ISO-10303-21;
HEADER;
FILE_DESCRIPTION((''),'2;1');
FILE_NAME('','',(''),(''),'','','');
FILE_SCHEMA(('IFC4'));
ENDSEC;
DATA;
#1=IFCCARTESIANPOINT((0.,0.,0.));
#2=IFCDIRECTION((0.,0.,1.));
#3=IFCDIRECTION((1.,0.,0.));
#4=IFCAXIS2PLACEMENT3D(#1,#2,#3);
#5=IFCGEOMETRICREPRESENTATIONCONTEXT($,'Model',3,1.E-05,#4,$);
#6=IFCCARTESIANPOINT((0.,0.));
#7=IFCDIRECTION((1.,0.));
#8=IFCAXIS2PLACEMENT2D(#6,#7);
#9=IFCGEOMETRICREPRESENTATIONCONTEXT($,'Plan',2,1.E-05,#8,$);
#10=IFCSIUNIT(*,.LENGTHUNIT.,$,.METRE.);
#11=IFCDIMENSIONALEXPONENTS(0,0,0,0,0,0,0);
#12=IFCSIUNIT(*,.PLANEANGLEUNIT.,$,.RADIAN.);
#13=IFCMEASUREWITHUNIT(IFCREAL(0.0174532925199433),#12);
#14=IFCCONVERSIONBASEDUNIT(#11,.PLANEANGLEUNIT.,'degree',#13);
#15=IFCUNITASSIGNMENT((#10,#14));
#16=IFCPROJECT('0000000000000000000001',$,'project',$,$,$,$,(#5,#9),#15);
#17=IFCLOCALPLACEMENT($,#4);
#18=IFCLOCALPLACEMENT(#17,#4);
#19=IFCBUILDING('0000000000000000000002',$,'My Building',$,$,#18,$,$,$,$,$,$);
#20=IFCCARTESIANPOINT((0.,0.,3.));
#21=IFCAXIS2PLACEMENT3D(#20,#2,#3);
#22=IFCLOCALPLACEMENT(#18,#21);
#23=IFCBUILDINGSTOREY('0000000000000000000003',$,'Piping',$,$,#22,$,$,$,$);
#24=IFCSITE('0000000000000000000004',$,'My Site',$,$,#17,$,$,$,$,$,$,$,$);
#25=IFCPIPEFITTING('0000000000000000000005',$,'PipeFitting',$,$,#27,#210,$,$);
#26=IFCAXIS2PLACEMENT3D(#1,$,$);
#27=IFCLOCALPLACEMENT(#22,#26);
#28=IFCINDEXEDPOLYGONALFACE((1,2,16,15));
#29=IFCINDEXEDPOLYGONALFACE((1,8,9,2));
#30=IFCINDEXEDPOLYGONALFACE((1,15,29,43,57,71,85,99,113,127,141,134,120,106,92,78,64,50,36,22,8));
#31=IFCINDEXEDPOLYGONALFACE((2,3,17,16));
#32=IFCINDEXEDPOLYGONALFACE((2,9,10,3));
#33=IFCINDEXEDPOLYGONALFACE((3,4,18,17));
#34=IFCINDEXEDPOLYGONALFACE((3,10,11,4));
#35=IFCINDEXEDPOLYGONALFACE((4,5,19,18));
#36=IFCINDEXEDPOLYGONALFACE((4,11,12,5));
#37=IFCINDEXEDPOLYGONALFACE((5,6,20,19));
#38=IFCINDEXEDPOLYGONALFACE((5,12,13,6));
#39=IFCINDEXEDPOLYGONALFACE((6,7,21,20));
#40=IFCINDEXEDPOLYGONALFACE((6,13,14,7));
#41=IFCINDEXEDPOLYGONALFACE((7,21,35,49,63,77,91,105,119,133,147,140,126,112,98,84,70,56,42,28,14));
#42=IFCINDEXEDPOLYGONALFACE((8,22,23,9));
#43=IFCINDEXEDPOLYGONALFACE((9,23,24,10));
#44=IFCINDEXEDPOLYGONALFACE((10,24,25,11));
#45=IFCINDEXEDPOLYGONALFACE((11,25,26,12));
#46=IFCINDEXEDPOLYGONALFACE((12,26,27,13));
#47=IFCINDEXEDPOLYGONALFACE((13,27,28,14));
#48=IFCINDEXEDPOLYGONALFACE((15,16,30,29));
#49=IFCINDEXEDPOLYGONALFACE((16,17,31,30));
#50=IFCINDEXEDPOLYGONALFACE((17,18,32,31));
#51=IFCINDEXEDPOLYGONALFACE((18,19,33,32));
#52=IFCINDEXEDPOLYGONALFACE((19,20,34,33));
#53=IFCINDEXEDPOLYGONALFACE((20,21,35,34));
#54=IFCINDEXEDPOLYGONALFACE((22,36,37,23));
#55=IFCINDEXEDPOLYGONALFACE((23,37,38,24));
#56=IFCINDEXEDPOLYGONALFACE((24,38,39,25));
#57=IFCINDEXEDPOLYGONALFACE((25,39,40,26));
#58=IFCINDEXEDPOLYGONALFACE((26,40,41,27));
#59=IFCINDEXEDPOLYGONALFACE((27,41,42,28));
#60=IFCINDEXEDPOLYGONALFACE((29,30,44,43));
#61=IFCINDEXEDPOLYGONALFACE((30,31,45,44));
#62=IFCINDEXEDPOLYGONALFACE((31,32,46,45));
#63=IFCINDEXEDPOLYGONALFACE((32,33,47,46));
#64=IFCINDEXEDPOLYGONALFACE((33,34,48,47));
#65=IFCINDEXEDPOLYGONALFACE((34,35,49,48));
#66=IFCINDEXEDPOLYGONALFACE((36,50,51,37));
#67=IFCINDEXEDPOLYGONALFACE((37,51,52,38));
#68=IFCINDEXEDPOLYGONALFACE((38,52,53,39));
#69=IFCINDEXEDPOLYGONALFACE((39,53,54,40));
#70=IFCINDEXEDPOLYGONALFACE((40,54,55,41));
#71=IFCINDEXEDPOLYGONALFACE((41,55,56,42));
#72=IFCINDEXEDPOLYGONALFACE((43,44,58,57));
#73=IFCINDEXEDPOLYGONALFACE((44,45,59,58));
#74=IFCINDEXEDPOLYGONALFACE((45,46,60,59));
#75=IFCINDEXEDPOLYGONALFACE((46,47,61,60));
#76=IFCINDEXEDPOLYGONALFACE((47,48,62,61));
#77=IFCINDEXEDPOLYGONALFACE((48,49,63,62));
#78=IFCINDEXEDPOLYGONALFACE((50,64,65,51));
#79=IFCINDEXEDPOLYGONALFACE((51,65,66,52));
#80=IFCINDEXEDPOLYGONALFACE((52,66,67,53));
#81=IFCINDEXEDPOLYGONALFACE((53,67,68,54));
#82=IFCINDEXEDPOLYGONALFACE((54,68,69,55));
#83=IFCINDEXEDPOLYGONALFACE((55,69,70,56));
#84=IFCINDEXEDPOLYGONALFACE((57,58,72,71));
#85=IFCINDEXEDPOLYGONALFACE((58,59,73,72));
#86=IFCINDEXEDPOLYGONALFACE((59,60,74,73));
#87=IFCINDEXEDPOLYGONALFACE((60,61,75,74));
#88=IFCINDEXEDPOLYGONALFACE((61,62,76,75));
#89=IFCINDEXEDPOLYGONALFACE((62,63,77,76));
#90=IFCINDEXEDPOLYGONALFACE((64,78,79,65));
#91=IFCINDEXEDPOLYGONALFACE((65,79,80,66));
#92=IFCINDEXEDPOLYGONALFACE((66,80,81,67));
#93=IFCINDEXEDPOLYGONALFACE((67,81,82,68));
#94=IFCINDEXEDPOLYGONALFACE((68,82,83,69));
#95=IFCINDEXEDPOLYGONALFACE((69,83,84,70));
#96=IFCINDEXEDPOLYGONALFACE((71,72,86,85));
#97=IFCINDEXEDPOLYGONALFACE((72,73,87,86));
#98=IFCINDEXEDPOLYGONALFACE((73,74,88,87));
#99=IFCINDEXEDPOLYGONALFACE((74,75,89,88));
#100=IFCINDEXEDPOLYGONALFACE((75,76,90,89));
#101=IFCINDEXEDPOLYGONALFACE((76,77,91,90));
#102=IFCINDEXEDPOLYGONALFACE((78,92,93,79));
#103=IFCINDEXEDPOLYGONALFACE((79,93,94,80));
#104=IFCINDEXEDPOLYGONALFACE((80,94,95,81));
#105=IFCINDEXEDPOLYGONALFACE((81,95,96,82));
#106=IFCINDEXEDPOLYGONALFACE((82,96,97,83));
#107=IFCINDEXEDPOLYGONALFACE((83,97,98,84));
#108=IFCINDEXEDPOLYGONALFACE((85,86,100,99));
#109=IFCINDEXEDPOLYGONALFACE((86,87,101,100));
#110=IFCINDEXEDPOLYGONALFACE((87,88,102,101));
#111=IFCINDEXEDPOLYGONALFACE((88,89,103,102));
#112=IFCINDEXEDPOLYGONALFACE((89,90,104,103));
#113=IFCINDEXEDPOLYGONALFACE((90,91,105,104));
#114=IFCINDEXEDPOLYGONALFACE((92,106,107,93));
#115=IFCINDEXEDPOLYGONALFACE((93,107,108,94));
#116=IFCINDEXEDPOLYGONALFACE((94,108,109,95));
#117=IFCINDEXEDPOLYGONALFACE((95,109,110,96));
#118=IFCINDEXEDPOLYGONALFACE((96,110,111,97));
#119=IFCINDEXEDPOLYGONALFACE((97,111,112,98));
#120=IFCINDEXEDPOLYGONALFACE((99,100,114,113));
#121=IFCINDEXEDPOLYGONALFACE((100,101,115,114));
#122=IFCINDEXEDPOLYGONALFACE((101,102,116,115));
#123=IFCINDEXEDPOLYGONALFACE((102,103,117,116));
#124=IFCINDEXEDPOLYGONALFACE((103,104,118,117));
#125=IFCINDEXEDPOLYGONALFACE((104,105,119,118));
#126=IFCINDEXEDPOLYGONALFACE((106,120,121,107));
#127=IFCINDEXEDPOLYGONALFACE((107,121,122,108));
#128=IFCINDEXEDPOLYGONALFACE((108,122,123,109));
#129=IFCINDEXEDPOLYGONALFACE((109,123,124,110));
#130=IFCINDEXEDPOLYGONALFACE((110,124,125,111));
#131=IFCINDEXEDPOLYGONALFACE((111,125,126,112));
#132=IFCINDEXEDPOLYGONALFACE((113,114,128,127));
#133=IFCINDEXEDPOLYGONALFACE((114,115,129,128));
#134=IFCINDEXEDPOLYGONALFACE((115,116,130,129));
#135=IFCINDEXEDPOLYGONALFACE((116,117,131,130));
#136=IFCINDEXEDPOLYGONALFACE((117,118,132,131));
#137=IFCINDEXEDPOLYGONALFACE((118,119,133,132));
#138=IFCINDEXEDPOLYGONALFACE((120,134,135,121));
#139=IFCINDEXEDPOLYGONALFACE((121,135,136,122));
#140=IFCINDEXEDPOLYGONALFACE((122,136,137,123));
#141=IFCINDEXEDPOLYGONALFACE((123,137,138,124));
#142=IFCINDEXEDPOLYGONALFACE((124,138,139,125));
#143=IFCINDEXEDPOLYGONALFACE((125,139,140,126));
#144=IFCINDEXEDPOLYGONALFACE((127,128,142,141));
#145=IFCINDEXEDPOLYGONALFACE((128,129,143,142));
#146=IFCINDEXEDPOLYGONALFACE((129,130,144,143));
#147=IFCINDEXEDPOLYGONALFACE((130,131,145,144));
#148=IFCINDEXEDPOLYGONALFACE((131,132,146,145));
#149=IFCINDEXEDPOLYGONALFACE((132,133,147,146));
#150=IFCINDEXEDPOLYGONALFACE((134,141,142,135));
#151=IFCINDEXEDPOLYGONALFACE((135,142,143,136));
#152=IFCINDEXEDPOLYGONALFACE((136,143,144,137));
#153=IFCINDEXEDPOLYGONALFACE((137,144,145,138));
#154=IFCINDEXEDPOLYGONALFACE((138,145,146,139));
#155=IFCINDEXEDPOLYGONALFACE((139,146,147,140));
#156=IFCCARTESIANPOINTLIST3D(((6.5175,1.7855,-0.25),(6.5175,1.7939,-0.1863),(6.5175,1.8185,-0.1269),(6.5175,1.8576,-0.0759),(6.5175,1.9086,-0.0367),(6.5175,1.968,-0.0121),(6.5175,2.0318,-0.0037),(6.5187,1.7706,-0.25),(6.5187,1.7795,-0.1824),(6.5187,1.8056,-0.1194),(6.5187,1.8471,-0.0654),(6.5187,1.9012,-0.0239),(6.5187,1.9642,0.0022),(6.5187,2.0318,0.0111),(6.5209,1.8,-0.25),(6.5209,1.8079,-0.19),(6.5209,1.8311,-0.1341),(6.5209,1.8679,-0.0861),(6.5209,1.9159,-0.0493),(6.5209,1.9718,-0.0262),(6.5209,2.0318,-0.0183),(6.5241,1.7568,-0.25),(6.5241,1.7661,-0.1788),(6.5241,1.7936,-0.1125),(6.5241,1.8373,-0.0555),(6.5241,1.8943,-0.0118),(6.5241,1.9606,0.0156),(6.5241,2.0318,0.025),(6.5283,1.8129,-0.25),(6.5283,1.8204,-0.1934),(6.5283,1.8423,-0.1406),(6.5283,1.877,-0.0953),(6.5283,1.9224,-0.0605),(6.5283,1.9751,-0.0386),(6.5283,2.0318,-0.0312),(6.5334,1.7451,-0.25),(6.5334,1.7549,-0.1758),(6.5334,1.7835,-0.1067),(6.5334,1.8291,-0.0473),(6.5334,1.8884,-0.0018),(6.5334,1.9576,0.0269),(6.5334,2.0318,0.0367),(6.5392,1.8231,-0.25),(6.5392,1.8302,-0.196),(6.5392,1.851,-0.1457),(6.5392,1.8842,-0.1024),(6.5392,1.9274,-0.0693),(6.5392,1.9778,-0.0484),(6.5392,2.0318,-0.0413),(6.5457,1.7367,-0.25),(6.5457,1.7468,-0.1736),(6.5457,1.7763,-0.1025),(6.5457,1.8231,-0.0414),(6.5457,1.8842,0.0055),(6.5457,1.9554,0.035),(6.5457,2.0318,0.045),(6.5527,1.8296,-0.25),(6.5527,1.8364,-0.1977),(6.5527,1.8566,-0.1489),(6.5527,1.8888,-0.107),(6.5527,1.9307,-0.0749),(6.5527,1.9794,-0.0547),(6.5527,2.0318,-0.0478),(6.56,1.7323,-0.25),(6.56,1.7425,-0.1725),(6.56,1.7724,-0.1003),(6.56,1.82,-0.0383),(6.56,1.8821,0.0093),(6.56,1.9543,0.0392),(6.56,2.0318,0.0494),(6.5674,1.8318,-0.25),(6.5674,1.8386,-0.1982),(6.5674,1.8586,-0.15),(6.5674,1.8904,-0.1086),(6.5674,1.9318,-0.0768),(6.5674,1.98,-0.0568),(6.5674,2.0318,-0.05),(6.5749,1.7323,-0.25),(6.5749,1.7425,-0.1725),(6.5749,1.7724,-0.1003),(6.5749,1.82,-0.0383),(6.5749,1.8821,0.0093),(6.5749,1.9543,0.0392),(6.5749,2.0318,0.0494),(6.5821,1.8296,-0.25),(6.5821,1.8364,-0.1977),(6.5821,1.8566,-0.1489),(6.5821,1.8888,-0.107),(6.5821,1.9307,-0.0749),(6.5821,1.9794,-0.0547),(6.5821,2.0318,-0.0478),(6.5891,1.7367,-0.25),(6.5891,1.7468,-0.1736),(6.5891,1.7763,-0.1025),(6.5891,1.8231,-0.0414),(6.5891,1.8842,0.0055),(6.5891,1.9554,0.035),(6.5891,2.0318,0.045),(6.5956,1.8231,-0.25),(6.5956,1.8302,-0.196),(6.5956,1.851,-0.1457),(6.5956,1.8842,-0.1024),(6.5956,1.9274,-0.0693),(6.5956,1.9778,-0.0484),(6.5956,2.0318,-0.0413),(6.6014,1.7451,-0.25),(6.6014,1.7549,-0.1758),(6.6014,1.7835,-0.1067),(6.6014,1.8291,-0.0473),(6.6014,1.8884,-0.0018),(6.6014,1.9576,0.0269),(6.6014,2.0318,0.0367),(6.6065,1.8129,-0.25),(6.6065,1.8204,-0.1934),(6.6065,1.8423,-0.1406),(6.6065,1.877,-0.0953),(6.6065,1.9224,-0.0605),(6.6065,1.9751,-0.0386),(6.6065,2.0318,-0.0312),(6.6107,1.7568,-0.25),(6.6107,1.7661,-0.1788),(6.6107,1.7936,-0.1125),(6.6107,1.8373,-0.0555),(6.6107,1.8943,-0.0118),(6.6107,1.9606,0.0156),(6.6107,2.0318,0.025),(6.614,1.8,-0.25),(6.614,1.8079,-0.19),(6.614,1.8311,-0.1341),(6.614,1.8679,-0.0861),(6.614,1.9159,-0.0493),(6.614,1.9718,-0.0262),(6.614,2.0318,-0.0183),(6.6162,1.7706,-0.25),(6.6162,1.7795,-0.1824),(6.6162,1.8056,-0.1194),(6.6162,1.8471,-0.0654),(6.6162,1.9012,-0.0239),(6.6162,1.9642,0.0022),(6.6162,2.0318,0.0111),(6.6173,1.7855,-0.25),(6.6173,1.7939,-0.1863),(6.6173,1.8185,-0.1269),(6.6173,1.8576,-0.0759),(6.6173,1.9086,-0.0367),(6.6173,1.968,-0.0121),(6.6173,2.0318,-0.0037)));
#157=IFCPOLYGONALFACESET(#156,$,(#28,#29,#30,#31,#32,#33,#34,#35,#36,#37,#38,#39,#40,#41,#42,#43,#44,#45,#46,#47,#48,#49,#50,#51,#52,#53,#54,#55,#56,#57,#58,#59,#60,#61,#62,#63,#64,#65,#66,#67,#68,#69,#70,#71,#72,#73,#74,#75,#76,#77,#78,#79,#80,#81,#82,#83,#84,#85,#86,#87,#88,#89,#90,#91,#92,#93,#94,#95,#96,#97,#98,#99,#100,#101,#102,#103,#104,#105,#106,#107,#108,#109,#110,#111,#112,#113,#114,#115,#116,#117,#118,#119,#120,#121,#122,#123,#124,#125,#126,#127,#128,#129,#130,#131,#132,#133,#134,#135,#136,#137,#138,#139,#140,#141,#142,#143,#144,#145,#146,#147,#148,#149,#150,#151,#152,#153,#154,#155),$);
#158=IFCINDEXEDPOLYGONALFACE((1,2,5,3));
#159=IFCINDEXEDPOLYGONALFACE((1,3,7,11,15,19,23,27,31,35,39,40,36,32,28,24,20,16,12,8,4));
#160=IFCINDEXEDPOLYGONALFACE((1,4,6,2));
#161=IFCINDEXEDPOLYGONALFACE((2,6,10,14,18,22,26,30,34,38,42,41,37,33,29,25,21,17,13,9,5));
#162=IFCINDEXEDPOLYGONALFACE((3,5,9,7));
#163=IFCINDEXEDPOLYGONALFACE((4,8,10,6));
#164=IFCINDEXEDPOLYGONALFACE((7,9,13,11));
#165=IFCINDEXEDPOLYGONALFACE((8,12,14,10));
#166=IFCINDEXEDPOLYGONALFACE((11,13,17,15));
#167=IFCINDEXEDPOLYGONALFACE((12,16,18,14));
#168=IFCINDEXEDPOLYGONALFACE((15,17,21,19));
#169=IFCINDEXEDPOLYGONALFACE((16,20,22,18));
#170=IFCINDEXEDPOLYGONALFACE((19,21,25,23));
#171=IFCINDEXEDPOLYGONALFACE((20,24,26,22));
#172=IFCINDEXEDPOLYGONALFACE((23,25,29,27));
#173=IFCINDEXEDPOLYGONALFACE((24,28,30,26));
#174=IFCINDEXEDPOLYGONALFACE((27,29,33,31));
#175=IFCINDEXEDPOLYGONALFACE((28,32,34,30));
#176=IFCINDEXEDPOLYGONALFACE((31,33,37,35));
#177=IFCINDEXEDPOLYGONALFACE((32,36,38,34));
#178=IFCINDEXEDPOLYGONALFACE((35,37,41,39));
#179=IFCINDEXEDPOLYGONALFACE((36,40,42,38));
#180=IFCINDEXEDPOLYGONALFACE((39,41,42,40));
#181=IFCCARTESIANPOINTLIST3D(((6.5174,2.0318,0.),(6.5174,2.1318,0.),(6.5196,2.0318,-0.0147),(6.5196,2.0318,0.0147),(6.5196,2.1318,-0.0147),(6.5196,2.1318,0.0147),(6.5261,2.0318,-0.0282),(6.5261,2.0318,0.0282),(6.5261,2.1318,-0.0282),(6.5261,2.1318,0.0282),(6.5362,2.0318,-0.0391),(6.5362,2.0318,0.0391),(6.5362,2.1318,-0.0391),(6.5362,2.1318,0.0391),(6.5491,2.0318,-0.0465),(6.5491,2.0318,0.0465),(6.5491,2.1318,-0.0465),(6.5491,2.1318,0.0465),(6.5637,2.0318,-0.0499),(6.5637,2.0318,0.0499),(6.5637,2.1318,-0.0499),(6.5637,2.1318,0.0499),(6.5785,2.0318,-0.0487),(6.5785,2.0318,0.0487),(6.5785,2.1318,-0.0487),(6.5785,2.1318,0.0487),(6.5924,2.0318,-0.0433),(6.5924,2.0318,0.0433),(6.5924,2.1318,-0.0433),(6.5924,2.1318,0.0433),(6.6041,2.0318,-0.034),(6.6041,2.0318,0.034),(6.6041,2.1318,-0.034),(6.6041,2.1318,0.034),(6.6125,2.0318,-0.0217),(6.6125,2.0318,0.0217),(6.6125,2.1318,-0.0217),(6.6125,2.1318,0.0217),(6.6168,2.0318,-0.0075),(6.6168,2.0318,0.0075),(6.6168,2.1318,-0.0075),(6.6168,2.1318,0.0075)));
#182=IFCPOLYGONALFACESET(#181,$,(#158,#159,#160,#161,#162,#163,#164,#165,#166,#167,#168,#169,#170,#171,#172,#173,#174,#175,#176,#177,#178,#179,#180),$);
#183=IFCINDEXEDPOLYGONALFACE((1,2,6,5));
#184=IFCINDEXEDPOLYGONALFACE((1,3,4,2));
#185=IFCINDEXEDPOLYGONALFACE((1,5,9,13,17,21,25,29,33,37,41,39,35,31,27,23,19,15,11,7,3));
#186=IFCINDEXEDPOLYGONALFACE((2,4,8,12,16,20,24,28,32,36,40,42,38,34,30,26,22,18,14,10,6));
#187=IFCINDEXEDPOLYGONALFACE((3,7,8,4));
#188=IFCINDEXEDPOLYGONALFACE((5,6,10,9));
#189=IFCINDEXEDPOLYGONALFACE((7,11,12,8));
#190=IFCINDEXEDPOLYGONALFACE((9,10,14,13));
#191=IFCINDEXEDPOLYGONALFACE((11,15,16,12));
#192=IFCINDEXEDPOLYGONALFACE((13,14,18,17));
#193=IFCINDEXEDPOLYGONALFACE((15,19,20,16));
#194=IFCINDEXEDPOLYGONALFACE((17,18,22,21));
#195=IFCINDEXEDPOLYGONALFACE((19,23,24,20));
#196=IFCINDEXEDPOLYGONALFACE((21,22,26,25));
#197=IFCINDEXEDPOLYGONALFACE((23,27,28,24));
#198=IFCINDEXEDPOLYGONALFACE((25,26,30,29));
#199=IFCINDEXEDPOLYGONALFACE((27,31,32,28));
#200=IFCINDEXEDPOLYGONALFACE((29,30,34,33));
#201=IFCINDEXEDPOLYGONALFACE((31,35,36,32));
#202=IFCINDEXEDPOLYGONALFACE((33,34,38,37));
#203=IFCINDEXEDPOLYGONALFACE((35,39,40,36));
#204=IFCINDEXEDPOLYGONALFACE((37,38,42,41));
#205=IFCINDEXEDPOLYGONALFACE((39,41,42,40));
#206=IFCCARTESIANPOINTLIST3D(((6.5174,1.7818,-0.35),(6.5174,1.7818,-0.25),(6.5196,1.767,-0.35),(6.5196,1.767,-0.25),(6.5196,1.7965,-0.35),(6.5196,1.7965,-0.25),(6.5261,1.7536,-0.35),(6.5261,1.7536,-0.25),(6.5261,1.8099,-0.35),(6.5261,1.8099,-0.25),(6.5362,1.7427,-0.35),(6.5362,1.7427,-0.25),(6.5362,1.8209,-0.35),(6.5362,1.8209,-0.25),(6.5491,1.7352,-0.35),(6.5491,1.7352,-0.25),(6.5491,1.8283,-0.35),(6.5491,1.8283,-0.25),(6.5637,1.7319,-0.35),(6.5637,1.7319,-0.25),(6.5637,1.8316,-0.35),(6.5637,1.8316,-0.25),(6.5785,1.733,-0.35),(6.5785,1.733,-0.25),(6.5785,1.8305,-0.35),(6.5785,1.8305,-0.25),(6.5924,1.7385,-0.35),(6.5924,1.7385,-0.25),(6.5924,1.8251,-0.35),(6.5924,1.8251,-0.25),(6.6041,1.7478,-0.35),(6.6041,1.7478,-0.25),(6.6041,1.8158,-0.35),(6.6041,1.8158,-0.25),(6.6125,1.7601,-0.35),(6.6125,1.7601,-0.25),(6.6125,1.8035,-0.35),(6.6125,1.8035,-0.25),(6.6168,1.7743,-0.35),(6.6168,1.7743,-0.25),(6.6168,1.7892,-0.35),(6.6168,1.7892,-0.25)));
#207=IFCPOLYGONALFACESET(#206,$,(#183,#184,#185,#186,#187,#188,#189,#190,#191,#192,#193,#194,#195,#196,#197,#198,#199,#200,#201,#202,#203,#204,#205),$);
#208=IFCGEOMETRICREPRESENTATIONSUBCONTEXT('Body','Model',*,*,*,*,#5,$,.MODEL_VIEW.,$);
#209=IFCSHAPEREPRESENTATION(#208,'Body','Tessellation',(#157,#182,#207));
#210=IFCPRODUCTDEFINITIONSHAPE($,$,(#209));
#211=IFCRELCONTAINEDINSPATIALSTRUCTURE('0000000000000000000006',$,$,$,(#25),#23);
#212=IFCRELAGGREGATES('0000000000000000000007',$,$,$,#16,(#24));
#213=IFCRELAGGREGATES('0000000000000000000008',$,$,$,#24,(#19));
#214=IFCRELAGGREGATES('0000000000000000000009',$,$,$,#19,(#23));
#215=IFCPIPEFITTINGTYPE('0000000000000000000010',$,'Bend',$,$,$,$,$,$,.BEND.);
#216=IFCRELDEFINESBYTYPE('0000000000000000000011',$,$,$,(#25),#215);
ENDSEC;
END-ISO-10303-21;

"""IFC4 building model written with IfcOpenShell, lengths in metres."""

from ifc_helpers import new_model, entity, si_unit, converted_unit, frame, origin_with_axes, origin_2d_with_axis, place, context, subcontext, project, spatial, circle, extrude, source, transform, mapped, type_object, type_shapes, element, save


model = new_model("IFC4")

# Units and contexts
model_context = context("Model", 3, precision=1e-05, world=origin_with_axes())
plan_context = context("Plan", 2, precision=1e-05, world=origin_2d_with_axis())
body_context = subcontext(model_context, "Body", "Model", "MODEL_VIEW")
ifc_project = project(units=[si_unit("LENGTHUNIT", "METRE"), converted_unit("PLANEANGLEUNIT", "degree", entity("IfcReal", 0.0174532925199433), si_unit("PLANEANGLEUNIT", "RADIAN"), dimensions=[0, 0, 0, 0, 0, 0, 0])], contexts=[model_context, plan_context])

# Site, building, storey
site_placement = place(None, origin_with_axes())
site = spatial("IfcSite", under=ifc_project, at=site_placement, Name="My Site")
building_placement = place(site_placement, origin_with_axes())
building = spatial("IfcBuilding", under=site, at=building_placement, Name="My Building")
storey_placement = place(building_placement, frame((0.0, 0.0, 3.0), z_axis=(0.0, 0.0, 1.0), x_axis=(1.0, 0.0, 0.0)))
storey = spatial("IfcBuildingStorey", under=building, at=storey_placement, Name="Piping")

# Pipe fitting
pipe_fitting_type = type_object("IfcPipeFittingType", Name="Bend", PredefinedType="BEND")
shared_shape = source(origin_with_axes(), body_context, "Body", "SolidModel", [
    entity("IfcSweptDiskSolid", entity("IfcIndexedPolyCurve", entity("IfcCartesianPointList3D", [[0.0, 0.0, -0.1], [0.0, -0.0732, -0.2768], [0.0, -0.25, -0.35]]), [entity("IfcArcIndex", [1, 2, 3])]), 0.05),
    extrude(circle(Radius=0.05), origin_with_axes(), (0.0, 0.0, -1.0), 0.1),
    extrude(circle(Radius=0.05), frame((0.0, -0.25, -0.35), z_axis=(0.0, -1.0, 0.0), x_axis=(1.0, 0.0, 0.0)), (0.0, 0.0, 1.0), 0.1),
])
type_shapes(pipe_fitting_type, [shared_shape])
for number, where, z_axis, x_axis, name in (
    (1, (6.5674, 2.1318, 0.0), (0.0, 1.0, 0.0), (-1.0, 0.0, 0.0), "PipeFitting"),
):
    element("IfcPipeFitting", number, at=place(storey_placement, frame(where, z_axis=z_axis, x_axis=x_axis)), inside=storey, type_object=pipe_fitting_type, Name=name, context=body_context, shape_type="MappedRepresentation", body=[
        mapped(shared_shape, transform((0.0, 0.0, 0.0), x_axis=(1.0, 0.0, 0.0), y_axis=(0.0, 1.0, 0.0), z_axis=(0.0, 0.0, 1.0), scale=1.0)),
    ])

save(model, "model.ifc")
